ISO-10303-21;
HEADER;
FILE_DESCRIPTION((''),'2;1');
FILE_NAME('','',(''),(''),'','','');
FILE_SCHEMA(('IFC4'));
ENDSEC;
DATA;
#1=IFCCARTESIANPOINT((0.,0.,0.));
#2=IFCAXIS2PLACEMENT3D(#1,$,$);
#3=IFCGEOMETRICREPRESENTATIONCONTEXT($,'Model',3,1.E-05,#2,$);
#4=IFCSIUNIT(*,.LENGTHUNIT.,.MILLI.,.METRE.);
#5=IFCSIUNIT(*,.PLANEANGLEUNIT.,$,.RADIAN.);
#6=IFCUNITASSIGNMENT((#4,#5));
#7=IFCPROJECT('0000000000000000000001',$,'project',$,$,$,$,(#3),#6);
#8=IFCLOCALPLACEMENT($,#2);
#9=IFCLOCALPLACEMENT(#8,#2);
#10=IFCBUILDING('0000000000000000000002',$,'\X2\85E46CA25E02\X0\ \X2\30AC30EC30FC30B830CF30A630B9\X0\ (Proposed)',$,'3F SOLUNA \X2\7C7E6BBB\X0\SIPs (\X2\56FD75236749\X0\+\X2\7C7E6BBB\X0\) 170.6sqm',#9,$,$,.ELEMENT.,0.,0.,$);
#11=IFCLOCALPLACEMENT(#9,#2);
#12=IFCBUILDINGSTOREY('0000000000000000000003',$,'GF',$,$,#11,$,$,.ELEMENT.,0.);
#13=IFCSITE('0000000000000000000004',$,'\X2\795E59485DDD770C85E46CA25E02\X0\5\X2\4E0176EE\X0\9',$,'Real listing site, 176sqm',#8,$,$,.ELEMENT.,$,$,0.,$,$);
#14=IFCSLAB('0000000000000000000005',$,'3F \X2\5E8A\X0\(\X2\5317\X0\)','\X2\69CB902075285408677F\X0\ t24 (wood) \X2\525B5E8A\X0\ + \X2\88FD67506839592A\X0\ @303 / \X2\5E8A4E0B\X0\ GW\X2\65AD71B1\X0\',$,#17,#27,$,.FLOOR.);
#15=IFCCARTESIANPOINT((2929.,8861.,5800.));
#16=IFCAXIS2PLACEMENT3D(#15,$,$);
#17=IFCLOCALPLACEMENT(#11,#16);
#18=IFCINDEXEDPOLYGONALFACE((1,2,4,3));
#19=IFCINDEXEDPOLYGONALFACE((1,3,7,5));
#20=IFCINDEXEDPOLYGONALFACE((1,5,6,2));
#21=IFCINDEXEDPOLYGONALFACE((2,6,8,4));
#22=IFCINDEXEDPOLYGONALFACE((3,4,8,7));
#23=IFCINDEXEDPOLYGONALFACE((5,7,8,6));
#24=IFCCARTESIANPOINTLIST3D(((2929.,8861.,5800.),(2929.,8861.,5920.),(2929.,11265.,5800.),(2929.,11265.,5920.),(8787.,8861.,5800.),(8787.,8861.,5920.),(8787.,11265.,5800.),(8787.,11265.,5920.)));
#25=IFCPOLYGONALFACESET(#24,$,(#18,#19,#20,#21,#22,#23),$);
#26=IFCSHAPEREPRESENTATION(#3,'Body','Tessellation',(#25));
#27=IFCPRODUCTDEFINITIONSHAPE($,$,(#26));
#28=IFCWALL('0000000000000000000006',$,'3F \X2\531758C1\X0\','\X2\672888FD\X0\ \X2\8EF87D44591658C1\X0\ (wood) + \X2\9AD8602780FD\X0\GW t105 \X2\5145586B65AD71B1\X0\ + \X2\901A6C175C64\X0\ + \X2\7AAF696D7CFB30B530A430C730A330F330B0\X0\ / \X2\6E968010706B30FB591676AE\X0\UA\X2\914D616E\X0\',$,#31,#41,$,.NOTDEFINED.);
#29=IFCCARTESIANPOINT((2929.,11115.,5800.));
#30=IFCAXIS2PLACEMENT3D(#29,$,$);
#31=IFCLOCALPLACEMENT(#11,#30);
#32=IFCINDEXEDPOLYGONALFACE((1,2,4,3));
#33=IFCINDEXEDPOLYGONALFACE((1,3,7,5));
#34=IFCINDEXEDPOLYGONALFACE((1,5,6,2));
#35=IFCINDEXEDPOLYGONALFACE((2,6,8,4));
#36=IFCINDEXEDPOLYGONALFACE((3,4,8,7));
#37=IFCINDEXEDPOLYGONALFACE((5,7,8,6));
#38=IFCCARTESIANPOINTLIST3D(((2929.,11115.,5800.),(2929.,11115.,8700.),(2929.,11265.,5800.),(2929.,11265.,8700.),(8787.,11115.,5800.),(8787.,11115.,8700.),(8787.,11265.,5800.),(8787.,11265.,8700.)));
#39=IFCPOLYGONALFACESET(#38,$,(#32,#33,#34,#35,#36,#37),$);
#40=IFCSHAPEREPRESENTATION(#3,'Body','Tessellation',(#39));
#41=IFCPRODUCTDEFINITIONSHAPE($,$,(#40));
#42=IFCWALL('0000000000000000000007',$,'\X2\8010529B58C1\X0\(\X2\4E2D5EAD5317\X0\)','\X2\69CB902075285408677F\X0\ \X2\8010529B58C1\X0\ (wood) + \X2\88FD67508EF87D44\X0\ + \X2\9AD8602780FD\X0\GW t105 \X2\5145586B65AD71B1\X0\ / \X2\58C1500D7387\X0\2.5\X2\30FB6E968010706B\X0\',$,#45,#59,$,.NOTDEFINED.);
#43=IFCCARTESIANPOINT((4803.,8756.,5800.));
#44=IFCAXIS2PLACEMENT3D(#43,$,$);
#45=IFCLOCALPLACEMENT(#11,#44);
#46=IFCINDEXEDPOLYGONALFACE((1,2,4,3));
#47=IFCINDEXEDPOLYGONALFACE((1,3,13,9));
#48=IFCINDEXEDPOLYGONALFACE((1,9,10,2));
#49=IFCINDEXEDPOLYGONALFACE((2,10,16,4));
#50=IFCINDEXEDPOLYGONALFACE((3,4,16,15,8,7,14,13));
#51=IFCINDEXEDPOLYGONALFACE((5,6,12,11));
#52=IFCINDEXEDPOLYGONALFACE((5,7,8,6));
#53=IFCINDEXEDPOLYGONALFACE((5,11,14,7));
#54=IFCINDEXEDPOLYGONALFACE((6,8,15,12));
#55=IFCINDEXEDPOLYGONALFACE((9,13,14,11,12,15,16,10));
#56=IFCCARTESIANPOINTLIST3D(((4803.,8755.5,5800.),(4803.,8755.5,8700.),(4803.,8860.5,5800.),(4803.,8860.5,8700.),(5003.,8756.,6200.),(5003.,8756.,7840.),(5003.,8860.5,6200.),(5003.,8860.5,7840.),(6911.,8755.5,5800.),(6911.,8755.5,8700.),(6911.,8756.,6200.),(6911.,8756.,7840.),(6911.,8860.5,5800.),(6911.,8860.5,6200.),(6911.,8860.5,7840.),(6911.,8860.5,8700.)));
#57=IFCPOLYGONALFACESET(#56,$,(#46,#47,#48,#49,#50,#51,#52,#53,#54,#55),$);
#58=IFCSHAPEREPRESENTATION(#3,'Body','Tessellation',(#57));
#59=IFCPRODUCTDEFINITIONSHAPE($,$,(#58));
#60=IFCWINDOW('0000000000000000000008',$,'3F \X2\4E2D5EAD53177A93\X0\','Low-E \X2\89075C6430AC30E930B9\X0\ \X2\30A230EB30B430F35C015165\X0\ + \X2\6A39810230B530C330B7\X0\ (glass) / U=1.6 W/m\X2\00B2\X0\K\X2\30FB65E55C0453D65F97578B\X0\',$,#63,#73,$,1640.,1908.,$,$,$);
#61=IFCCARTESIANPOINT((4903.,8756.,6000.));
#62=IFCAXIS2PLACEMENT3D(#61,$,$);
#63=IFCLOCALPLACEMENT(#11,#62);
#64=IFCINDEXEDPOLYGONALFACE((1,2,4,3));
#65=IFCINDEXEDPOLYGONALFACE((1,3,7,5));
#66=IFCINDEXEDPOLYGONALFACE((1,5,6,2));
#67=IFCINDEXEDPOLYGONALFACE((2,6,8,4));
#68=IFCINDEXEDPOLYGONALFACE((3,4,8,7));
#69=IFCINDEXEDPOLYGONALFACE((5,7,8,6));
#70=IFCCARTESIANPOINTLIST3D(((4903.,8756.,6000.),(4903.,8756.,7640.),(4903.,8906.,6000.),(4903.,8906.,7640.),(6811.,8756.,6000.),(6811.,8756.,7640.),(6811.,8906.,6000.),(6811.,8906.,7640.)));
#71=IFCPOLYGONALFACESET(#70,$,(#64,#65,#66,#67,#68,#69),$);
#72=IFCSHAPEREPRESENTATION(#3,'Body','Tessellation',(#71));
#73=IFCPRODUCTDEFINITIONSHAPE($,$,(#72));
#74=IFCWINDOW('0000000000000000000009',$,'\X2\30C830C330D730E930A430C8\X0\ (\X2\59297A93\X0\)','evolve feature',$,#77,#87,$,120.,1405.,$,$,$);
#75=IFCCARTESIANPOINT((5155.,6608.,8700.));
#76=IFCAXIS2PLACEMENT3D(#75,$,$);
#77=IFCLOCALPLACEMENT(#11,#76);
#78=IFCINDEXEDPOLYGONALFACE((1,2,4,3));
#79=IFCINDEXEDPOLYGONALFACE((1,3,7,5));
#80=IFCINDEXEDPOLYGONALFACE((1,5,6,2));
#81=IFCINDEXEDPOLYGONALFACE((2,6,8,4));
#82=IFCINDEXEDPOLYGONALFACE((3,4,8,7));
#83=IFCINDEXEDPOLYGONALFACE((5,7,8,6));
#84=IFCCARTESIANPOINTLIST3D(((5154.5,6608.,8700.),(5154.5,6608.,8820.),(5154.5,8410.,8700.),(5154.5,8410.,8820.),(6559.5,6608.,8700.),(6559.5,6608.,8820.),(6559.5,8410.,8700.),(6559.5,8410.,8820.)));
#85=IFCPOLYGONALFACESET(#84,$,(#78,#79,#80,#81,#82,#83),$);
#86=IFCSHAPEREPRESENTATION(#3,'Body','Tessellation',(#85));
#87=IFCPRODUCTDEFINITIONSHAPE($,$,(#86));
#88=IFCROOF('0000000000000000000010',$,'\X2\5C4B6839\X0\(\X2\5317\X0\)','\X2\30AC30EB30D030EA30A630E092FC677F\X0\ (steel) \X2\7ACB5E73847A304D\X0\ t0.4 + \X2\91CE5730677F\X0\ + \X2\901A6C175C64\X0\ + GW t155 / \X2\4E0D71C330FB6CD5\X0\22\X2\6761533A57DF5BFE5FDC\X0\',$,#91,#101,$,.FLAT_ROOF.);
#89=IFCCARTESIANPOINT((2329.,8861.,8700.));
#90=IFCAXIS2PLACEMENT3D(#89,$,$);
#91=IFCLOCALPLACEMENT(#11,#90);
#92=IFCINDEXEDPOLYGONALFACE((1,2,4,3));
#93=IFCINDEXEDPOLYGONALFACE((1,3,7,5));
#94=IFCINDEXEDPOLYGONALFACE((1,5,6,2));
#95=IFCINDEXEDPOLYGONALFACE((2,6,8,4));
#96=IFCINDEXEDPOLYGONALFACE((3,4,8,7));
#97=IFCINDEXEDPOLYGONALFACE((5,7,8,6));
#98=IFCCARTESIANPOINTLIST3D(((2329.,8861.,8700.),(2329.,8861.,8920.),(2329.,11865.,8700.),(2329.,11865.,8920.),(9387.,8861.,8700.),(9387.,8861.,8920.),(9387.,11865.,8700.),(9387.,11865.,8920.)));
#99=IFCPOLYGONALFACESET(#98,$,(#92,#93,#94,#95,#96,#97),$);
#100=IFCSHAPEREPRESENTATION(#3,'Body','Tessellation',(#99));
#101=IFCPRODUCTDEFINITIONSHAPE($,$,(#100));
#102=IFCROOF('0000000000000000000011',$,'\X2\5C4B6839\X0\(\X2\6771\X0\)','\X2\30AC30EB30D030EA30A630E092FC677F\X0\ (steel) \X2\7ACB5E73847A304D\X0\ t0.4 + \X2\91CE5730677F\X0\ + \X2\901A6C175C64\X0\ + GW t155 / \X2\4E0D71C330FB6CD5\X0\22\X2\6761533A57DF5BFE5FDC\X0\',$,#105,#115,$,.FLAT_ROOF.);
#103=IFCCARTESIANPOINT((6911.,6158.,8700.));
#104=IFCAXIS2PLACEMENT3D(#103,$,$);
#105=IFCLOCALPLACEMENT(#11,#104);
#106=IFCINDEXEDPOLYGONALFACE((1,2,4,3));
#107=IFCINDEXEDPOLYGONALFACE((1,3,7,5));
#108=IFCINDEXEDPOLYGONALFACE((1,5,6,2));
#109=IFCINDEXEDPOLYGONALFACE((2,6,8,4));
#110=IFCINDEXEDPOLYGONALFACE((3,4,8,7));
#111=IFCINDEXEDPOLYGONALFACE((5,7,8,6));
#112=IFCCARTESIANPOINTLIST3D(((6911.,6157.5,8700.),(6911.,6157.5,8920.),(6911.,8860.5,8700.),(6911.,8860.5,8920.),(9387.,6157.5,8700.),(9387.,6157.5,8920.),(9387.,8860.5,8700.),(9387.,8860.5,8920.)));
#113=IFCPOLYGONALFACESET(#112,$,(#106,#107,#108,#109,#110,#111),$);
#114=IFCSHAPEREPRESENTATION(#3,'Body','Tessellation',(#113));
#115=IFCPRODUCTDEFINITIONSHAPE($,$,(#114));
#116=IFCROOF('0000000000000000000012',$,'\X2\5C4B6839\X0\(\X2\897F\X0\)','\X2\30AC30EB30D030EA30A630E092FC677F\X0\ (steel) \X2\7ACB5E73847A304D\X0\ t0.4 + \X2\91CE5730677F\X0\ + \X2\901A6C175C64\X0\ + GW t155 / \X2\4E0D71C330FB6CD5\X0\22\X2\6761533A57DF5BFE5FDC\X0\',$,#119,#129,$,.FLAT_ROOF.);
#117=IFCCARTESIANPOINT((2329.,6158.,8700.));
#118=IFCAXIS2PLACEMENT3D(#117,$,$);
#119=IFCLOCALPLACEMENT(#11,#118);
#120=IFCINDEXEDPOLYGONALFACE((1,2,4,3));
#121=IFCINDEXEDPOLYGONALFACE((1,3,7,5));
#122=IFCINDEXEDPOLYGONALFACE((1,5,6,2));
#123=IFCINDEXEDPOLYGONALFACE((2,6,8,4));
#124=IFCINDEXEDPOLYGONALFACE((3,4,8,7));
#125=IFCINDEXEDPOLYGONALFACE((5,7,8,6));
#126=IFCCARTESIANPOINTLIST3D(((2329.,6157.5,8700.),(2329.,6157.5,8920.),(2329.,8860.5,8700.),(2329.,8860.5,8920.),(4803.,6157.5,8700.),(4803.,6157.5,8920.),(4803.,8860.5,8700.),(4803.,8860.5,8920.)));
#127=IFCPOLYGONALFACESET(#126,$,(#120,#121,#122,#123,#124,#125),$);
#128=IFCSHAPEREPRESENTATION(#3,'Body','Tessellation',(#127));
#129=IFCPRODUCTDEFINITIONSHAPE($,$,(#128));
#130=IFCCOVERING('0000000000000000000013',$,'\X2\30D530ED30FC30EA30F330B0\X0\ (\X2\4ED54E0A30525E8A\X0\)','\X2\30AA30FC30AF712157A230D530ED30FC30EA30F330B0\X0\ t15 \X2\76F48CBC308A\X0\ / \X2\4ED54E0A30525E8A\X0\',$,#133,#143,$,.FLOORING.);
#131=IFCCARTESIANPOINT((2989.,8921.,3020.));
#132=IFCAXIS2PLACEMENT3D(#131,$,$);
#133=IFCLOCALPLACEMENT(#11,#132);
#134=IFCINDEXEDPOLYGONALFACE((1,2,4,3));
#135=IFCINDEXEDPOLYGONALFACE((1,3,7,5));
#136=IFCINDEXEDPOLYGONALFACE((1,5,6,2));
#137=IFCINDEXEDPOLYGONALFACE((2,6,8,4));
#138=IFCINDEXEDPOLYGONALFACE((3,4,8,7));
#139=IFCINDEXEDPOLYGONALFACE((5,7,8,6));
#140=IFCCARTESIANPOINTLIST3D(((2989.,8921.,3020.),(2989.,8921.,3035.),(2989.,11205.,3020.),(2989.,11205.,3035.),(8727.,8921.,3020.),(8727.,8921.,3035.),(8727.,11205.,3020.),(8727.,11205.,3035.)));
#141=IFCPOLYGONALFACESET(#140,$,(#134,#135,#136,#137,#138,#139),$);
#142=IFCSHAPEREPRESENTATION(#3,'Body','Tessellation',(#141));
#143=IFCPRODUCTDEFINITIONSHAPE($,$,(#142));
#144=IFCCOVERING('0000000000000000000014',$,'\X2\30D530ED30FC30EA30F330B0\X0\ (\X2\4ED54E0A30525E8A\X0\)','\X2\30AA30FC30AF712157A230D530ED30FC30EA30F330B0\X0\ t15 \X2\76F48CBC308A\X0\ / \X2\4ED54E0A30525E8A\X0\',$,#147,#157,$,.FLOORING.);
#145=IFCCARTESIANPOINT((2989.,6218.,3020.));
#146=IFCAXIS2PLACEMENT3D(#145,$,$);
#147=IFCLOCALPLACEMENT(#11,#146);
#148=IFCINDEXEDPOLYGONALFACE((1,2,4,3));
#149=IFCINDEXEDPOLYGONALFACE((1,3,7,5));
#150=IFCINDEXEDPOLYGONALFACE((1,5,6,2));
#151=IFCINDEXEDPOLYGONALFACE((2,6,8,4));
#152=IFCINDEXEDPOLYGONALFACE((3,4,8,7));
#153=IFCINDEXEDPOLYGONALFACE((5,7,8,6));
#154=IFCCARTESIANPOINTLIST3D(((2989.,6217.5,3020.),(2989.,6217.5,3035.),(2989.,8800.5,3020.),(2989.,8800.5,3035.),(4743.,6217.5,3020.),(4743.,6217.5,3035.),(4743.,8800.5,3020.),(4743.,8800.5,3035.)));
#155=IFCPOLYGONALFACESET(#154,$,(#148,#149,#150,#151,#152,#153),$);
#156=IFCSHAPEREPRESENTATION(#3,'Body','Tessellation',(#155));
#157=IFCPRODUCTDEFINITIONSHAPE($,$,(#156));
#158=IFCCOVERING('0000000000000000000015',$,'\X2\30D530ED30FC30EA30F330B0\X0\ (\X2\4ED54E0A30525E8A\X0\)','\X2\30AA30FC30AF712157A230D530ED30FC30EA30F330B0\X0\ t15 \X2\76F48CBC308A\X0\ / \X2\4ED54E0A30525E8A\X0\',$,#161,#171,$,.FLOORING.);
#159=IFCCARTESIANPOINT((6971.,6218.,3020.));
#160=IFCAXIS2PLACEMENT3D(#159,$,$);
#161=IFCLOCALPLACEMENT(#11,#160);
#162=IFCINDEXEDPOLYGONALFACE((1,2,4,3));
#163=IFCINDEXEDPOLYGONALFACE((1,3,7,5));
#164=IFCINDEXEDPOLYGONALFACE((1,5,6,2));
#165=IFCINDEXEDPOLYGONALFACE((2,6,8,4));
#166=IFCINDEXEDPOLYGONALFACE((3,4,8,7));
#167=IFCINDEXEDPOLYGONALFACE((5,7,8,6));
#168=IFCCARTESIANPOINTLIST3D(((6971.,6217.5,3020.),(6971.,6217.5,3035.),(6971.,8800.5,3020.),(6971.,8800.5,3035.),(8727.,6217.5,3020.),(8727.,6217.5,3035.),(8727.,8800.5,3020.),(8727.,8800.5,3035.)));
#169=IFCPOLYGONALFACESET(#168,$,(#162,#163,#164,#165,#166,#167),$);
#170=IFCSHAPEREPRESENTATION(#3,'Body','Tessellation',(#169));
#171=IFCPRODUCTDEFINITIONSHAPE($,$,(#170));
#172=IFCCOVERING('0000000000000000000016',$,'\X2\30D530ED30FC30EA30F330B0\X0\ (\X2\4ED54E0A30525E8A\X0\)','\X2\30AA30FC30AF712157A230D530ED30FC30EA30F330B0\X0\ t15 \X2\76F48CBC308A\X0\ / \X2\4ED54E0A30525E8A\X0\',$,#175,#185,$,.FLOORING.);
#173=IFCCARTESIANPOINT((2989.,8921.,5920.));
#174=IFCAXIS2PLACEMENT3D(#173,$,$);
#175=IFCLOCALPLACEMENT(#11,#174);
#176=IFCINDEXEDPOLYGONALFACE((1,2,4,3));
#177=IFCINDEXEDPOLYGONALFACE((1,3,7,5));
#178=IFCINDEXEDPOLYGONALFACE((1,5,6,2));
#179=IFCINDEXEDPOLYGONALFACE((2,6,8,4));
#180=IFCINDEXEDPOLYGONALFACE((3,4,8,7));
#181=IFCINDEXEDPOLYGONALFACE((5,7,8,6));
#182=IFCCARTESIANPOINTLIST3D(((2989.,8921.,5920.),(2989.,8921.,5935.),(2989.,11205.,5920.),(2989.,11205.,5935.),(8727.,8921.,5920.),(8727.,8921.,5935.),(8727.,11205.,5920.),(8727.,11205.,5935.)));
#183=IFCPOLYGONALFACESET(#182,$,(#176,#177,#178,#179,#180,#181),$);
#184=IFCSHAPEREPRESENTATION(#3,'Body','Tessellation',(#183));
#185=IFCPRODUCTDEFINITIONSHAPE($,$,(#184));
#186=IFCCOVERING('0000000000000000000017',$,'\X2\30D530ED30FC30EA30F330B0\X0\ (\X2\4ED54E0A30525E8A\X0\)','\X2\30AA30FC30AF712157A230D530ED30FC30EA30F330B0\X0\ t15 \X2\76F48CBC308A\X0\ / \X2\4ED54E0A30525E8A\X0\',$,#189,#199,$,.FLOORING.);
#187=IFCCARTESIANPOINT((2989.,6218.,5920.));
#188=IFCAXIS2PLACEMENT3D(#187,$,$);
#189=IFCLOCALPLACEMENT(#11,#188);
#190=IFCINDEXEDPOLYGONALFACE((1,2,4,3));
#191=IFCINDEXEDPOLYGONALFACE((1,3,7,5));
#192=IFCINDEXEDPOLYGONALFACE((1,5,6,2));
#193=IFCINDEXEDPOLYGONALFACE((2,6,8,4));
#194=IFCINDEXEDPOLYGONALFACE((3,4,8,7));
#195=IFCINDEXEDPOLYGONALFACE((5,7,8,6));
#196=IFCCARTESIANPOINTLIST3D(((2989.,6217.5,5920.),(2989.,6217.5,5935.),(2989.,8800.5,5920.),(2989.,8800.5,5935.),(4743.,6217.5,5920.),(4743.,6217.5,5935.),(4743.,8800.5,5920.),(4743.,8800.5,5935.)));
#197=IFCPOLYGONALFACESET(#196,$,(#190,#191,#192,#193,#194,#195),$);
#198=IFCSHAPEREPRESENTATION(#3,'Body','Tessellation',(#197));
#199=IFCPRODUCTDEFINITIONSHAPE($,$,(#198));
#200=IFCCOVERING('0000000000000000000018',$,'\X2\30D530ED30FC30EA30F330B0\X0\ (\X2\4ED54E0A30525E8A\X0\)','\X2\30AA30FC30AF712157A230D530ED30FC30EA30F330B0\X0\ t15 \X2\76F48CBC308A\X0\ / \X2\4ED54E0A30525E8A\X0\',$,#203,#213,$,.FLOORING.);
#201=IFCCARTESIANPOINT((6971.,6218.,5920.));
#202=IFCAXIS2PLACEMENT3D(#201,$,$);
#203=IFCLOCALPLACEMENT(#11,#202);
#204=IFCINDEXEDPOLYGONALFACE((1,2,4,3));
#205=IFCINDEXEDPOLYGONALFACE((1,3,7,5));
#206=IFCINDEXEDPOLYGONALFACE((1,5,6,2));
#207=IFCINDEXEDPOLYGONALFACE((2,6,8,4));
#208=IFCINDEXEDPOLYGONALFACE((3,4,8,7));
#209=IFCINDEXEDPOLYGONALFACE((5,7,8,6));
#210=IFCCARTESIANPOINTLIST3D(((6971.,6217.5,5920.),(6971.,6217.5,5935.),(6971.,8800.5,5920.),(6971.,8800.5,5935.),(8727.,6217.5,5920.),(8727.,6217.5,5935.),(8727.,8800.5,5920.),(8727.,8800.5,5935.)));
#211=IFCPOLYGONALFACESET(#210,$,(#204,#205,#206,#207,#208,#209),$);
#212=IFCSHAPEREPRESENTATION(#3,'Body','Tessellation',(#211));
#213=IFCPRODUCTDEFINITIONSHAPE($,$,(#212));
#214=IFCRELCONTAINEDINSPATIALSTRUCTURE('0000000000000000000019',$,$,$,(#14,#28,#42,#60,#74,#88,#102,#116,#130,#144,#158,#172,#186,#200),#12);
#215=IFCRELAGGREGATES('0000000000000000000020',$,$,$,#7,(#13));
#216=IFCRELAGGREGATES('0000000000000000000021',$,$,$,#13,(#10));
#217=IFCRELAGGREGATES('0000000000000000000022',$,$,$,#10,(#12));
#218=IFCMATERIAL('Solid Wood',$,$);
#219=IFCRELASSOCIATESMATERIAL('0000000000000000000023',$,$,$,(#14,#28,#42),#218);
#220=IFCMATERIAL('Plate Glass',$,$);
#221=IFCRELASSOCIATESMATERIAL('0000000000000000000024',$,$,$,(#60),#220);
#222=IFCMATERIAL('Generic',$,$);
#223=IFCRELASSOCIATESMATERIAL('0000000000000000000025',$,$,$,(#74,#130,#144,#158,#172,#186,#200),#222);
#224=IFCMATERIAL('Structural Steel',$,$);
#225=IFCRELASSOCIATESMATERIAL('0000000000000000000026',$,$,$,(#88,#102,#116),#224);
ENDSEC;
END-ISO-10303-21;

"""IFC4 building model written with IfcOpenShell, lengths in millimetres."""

from ifc_helpers import new_model, si_unit, frame, frame_2d, origin, place, context, project, spatial, rectangle, extrude, material, element, fill, save


model = new_model("IFC4")

# Units and contexts
model_context = context("Model", 3, precision=1e-05, world=origin())
ifc_project = project(units=[si_unit("LENGTHUNIT", "METRE", prefix="MILLI"), si_unit("PLANEANGLEUNIT", "RADIAN")], contexts=[model_context])

# Site, building, storey
site_placement = place(None, origin())
site = spatial("IfcSite", under=ifc_project, at=site_placement, Name="神奈川県藤沢市5丁目9", ObjectType="Real listing site, 176sqm", CompositionType="ELEMENT", RefElevation=0.0)
building_placement = place(site_placement, origin())
building = spatial("IfcBuilding", under=site, at=building_placement, Name="藤沢市 ガレージハウス (Proposed)", ObjectType="3F SOLUNA 籾殻SIPs (国産杉+籾殻) 170.6sqm", CompositionType="ELEMENT", ElevationOfRefHeight=0.0, ElevationOfTerrain=0.0)
storey_placement = place(building_placement, origin())
storey = spatial("IfcBuildingStorey", under=building, at=storey_placement, Name="GF", CompositionType="ELEMENT", Elevation=0.0)

# Slab
ifc_material_1 = material(Name="Solid Wood")
slab_placement = place(storey_placement, frame((2929.0, 8861.0, 5800.0)))
element("IfcSlab", 1, at=slab_placement, inside=storey, material=ifc_material_1, Name="3F 床(北)", Description="構造用合板 t24 (wood) 剛床 + 製材根太 @303 / 床下 GW断熱", PredefinedType="FLOOR", context=model_context, shape_type="SweptSolid", body=[
    extrude(rectangle(XDim=5858.0, YDim=2404.0, at=frame_2d((2929.0, 1202.0))), frame((2929.0, 8861.0, 5800.0)), (0.0, 0.0, 1.0), 120.0),
])

# Wall
wall_1_placement = place(storey_placement, frame((2929.0, 11115.0, 5800.0)))
element("IfcWall", 2, at=wall_1_placement, inside=storey, material=ifc_material_1, Name="3F 北壁", Description="木製 軸組外壁 (wood) + 高性能GW t105 充填断熱 + 通気層 + 窯業系サイディング / 準耐火・外皮UA配慮", PredefinedType="NOTDEFINED", context=model_context, shape_type="SweptSolid", body=[
    extrude(rectangle(XDim=5858.0, YDim=150.0, at=frame_2d((2929.0, 75.0))), frame((2929.0, 11115.0, 5800.0)), (0.0, 0.0, 1.0), 2900.0),
])

# Wall, opening, window
wall_2_placement = place(storey_placement, frame((4803.0, 8756.0, 5800.0)))
wall_2 = element("IfcWall", 3, at=wall_2_placement, inside=storey, material=ifc_material_1, Name="耐力壁(中庭北)", Description="構造用合板 耐力壁 (wood) + 製材軸組 + 高性能GW t105 充填断熱 / 壁倍率2.5・準耐火", PredefinedType="NOTDEFINED", context=model_context, shape_type="SweptSolid", body=[
    extrude(rectangle(XDim=2108.0, YDim=105.0, at=frame_2d((1054.0, 52.0))), frame((4803.0, 8756.0, 5800.0)), (0.0, 0.0, 1.0), 2900.0),
])
opening_placement = place(storey_placement, frame((4903.0, 8756.0, 6000.0)))
opening = element("IfcOpeningElement", 4, at=opening_placement, cuts=wall_2, PredefinedType="NOTDEFINED", context=model_context, shape_type="SweptSolid", body=[
    extrude(rectangle(XDim=1908.0, YDim=150.0, at=frame_2d((954.0, 75.0))), frame((4903.0, 8756.0, 6000.0)), (0.0, 0.0, 1.0), 1640.0),
])
ifc_material_2 = material(Name="Plate Glass")
window_1_placement = place(storey_placement, frame((4903.0, 8756.0, 6000.0)))
window_1 = element("IfcWindow", 5, at=window_1_placement, inside=storey, material=ifc_material_2, Name="3F 中庭北窓", Description="Low-E 複層ガラス アルゴン封入 + 樹脂サッシ (glass) / U=1.6 W/m²K・日射取得型", OverallHeight=1640.0, OverallWidth=1908.0, context=model_context, shape_type="SweptSolid", body=[
    extrude(rectangle(XDim=1908.0, YDim=150.0, at=frame_2d((954.0, 75.0))), frame((4903.0, 8756.0, 6000.0)), (0.0, 0.0, 1.0), 1640.0),
])
fill(opening, window_1)

# Window
ifc_material_3 = material(Name="Generic")
window_2_placement = place(storey_placement, frame((5155.0, 6608.0, 8700.0)))
element("IfcWindow", 6, at=window_2_placement, inside=storey, material=ifc_material_3, Name="トップライト (天窓)", Description="evolve feature", OverallHeight=120.0, OverallWidth=1405.0, context=model_context, shape_type="SweptSolid", body=[
    extrude(rectangle(XDim=1405.0, YDim=1802.0, at=frame_2d((702.0, 901.0))), frame((5155.0, 6608.0, 8700.0)), (0.0, 0.0, 1.0), 120.0),
])

# Roofs
ifc_material_4 = material(Name="Structural Steel")
roof_1_placement = place(storey_placement, frame((2329.0, 8861.0, 8700.0)))
element("IfcRoof", 7, at=roof_1_placement, inside=storey, material=ifc_material_4, Name="屋根(北)", Description="ガルバリウム鋼板 (steel) 立平葺き t0.4 + 野地板 + 通気層 + GW t155 / 不燃・法22条区域対応", PredefinedType="FLAT_ROOF", context=model_context, shape_type="SweptSolid", body=[
    extrude(rectangle(XDim=7058.0, YDim=3004.0, at=frame_2d((3529.0, 1502.0))), frame((2329.0, 8861.0, 8700.0)), (0.0, 0.0, 1.0), 220.0),
])
roof_2_placement = place(storey_placement, frame((6911.0, 6158.0, 8700.0)))
element("IfcRoof", 8, at=roof_2_placement, inside=storey, material=ifc_material_4, Name="屋根(東)", Description="ガルバリウム鋼板 (steel) 立平葺き t0.4 + 野地板 + 通気層 + GW t155 / 不燃・法22条区域対応", PredefinedType="FLAT_ROOF", context=model_context, shape_type="SweptSolid", body=[
    extrude(rectangle(XDim=2476.0, YDim=2703.0, at=frame_2d((1238.0, 1351.0))), frame((6911.0, 6158.0, 8700.0)), (0.0, 0.0, 1.0), 220.0),
])
roof_3_placement = place(storey_placement, frame((2329.0, 6158.0, 8700.0)))
element("IfcRoof", 9, at=roof_3_placement, inside=storey, material=ifc_material_4, Name="屋根(西)", Description="ガルバリウム鋼板 (steel) 立平葺き t0.4 + 野地板 + 通気層 + GW t155 / 不燃・法22条区域対応", PredefinedType="FLAT_ROOF", context=model_context, shape_type="SweptSolid", body=[
    extrude(rectangle(XDim=2474.0, YDim=2703.0, at=frame_2d((1237.0, 1351.0))), frame((2329.0, 6158.0, 8700.0)), (0.0, 0.0, 1.0), 220.0),
])

# Coverings
covering_1_placement = place(storey_placement, frame((2989.0, 8921.0, 3020.0)))
element("IfcCovering", 10, at=covering_1_placement, inside=storey, material=ifc_material_3, Name="フローリング (仕上げ床)", Description="オーク無垢フローリング t15 直貼り / 仕上げ床", PredefinedType="FLOORING", context=model_context, shape_type="SweptSolid", body=[
    extrude(rectangle(XDim=5738.0, YDim=2284.0, at=frame_2d((2869.0, 1142.0))), frame((2989.0, 8921.0, 3020.0)), (0.0, 0.0, 1.0), 15.0),
])
covering_2_placement = place(storey_placement, frame((2989.0, 6218.0, 3020.0)))
element("IfcCovering", 11, at=covering_2_placement, inside=storey, material=ifc_material_3, Name="フローリング (仕上げ床)", Description="オーク無垢フローリング t15 直貼り / 仕上げ床", PredefinedType="FLOORING", context=model_context, shape_type="SweptSolid", body=[
    extrude(rectangle(XDim=1754.0, YDim=2583.0, at=frame_2d((877.0, 1291.0))), frame((2989.0, 6218.0, 3020.0)), (0.0, 0.0, 1.0), 15.0),
])
covering_3_placement = place(storey_placement, frame((6971.0, 6218.0, 3020.0)))
element("IfcCovering", 12, at=covering_3_placement, inside=storey, material=ifc_material_3, Name="フローリング (仕上げ床)", Description="オーク無垢フローリング t15 直貼り / 仕上げ床", PredefinedType="FLOORING", context=model_context, shape_type="SweptSolid", body=[
    extrude(rectangle(XDim=1756.0, YDim=2583.0, at=frame_2d((878.0, 1291.0))), frame((6971.0, 6218.0, 3020.0)), (0.0, 0.0, 1.0), 15.0),
])
covering_4_placement = place(storey_placement, frame((2989.0, 8921.0, 5920.0)))
element("IfcCovering", 13, at=covering_4_placement, inside=storey, material=ifc_material_3, Name="フローリング (仕上げ床)", Description="オーク無垢フローリング t15 直貼り / 仕上げ床", PredefinedType="FLOORING", context=model_context, shape_type="SweptSolid", body=[
    extrude(rectangle(XDim=5738.0, YDim=2284.0, at=frame_2d((2869.0, 1142.0))), frame((2989.0, 8921.0, 5920.0)), (0.0, 0.0, 1.0), 15.0),
])
covering_5_placement = place(storey_placement, frame((2989.0, 6218.0, 5920.0)))
element("IfcCovering", 14, at=covering_5_placement, inside=storey, material=ifc_material_3, Name="フローリング (仕上げ床)", Description="オーク無垢フローリング t15 直貼り / 仕上げ床", PredefinedType="FLOORING", context=model_context, shape_type="SweptSolid", body=[
    extrude(rectangle(XDim=1754.0, YDim=2583.0, at=frame_2d((877.0, 1291.0))), frame((2989.0, 6218.0, 5920.0)), (0.0, 0.0, 1.0), 15.0),
])
covering_6_placement = place(storey_placement, frame((6971.0, 6218.0, 5920.0)))
element("IfcCovering", 15, at=covering_6_placement, inside=storey, material=ifc_material_3, Name="フローリング (仕上げ床)", Description="オーク無垢フローリング t15 直貼り / 仕上げ床", PredefinedType="FLOORING", context=model_context, shape_type="SweptSolid", body=[
    extrude(rectangle(XDim=1756.0, YDim=2583.0, at=frame_2d((878.0, 1291.0))), frame((6971.0, 6218.0, 5920.0)), (0.0, 0.0, 1.0), 15.0),
])

save(model, "model.ifc")
